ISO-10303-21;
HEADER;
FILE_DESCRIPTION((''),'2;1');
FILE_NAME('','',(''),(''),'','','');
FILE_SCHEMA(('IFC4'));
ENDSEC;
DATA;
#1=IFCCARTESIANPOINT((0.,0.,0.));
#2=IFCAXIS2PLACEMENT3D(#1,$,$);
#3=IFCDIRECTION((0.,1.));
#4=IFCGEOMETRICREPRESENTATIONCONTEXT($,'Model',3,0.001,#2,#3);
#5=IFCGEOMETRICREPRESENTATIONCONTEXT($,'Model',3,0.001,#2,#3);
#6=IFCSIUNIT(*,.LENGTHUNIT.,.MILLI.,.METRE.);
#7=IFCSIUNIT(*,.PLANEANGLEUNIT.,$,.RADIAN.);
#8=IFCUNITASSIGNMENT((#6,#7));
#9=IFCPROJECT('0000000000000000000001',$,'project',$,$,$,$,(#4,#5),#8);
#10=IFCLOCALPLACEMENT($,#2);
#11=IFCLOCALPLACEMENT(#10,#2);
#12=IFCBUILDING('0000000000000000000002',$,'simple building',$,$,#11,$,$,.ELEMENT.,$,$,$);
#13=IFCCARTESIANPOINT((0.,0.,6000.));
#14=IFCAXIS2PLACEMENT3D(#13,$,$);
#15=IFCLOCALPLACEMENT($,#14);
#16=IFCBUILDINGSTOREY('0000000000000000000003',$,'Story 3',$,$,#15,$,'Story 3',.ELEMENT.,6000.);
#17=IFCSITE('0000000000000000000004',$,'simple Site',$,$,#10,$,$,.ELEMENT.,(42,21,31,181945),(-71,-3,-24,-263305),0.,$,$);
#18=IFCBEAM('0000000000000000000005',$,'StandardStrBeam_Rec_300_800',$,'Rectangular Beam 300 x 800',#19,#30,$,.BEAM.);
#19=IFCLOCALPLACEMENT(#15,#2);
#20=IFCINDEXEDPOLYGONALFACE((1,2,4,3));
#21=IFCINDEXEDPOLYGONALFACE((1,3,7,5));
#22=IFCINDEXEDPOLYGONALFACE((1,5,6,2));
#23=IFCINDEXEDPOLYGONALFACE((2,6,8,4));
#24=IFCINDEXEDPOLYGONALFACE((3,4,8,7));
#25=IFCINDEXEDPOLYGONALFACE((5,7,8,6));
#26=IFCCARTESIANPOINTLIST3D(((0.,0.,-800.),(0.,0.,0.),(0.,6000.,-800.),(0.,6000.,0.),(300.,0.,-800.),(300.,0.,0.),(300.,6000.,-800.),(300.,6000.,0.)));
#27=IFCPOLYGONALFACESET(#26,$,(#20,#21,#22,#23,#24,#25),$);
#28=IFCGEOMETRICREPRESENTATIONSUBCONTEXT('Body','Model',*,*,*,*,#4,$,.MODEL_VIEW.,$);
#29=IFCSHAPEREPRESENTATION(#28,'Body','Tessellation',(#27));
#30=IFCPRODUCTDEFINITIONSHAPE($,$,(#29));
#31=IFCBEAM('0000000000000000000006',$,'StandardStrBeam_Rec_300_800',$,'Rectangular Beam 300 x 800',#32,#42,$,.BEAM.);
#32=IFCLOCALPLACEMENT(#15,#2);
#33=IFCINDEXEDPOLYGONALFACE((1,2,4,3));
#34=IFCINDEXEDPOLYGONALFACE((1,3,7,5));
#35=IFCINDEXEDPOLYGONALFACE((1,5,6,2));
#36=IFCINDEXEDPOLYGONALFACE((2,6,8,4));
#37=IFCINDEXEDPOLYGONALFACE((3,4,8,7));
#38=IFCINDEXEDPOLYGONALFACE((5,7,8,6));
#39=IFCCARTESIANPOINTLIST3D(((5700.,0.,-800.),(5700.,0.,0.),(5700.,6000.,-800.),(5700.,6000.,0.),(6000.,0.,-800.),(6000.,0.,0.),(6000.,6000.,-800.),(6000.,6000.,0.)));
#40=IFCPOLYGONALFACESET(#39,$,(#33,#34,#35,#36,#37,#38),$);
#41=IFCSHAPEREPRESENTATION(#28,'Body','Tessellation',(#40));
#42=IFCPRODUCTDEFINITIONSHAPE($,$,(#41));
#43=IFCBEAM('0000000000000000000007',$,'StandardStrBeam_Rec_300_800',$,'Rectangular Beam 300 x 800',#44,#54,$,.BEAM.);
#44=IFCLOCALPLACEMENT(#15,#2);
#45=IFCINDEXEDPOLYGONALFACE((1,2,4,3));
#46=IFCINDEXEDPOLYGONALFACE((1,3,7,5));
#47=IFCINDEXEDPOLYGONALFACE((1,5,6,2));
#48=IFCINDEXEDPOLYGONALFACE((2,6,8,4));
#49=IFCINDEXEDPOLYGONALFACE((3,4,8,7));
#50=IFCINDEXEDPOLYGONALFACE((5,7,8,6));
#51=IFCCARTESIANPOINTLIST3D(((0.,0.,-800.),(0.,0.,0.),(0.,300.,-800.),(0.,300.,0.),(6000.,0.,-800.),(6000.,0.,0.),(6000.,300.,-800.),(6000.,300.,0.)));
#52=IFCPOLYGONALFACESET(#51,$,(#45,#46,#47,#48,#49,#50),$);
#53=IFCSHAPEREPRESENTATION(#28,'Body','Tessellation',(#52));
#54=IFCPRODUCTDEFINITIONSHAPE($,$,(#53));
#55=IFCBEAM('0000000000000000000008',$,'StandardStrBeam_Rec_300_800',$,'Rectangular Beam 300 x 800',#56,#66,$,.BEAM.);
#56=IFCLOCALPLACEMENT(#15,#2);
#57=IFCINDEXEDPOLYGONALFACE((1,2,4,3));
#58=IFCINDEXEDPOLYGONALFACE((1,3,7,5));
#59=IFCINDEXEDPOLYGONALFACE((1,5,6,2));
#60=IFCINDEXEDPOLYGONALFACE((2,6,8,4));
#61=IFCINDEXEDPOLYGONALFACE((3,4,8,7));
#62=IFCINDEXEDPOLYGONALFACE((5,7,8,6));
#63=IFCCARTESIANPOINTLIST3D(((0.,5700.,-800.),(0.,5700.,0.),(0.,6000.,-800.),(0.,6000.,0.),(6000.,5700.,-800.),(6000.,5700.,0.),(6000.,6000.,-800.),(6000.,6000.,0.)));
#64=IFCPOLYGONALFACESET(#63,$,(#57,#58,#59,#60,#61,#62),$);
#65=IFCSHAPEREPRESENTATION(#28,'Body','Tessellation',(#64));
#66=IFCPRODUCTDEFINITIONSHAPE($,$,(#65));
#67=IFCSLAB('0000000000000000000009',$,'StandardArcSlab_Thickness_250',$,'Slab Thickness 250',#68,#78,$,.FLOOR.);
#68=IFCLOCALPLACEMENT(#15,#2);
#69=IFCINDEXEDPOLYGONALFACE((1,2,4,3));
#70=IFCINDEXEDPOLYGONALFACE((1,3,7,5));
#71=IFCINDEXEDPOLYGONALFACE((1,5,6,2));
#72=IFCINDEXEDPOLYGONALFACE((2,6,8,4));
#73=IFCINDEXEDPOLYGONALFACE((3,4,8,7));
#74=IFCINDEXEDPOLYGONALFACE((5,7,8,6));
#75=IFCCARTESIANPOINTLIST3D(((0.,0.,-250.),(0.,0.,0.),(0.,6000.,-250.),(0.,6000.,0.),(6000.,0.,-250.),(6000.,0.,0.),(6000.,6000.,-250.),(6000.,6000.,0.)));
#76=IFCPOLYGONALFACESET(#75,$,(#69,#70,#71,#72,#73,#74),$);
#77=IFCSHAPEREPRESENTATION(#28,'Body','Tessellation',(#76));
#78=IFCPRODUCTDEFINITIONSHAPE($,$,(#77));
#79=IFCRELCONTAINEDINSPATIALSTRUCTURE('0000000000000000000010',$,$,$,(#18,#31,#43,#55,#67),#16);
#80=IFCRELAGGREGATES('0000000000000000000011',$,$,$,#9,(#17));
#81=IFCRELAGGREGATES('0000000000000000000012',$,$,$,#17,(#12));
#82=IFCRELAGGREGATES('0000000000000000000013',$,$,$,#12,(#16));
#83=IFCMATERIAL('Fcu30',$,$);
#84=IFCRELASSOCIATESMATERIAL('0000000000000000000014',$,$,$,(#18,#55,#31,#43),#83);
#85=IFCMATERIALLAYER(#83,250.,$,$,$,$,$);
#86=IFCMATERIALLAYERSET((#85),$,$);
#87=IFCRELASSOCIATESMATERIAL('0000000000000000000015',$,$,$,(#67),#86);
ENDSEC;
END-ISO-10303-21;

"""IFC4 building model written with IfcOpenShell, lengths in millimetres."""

from ifc_helpers import new_model, si_unit, direction, frame, origin, origin_with_axes, origin_2d_with_axis, place, context, subcontext, project, spatial, polyline, rectangle, outline, extrude, material, layer, layer_set, layer_usage, material_profile, profile_set, profile_usage, element, save


model = new_model("IFC4")

# Units and contexts
model_context_1 = context("Model", 3, precision=0.001, world=origin(), true_north=direction((0.0, 1.0)))
model_context_2 = context("Model", 3, precision=0.001, world=origin(), true_north=direction((0.0, 1.0)))
body_context = subcontext(model_context_1, "Body", "Model", "MODEL_VIEW")
ifc_project = project(units=[si_unit("LENGTHUNIT", "METRE", prefix="MILLI"), si_unit("PLANEANGLEUNIT", "RADIAN")], contexts=[model_context_1, model_context_2])

# Site, building, storey
site_placement = place(None, origin())
site = spatial("IfcSite", under=ifc_project, at=site_placement, Name="simple Site", CompositionType="ELEMENT", RefLatitude=(42, 21, 31, 181945), RefLongitude=(-71, -3, -24, -263305), RefElevation=0.0)
building_placement = place(site_placement, origin())
building = spatial("IfcBuilding", under=site, at=building_placement, Name="simple building", CompositionType="ELEMENT")
storey_placement = place(None, frame((0.0, 0.0, 6000.0)))
storey = spatial("IfcBuildingStorey", under=building, at=storey_placement, Name="Story 3", LongName="Story 3", CompositionType="ELEMENT", Elevation=6000.0)

# Beams
ifc_material = material(Name="Fcu30")
ifc_material_profile = material_profile(ifc_material, rectangle(XDim=300.0, YDim=800.0, at=origin_2d_with_axis()))
ifc_profile_set = profile_set([ifc_material_profile])
ifc_profile_usage_1 = profile_usage(ifc_profile_set, cardinal=7)
beam_1_placement = place(None, frame((150.0, 0.0, 5600.0), z_axis=(0.0, 1.0, 0.0), x_axis=(1.0, 0.0, 0.0)))
element("IfcBeam", 1, at=beam_1_placement, inside=storey, material=ifc_profile_usage_1, Name="StandardStrBeam_Rec_300_800", ObjectType="Rectangular Beam 300 x 800", PredefinedType="BEAM", context=body_context, shape_type="SweptSolid", body=[
    extrude(rectangle(XDim=300.0, YDim=800.0, at=origin_2d_with_axis()), origin_with_axes(), (0.0, 0.0, 1.0), 6000.0),
])
ifc_profile_usage_2 = profile_usage(ifc_profile_set, cardinal=9)
for number, where, z_axis, x_axis, name in (
    (2, (5850.0, 0.0, 5600.0), (0.0, 1.0, 0.0), (1.0, 0.0, 0.0), "StandardStrBeam_Rec_300_800"),
    (3, (0.0, 150.0, 5600.0), (1.0, 0.0, 0.0), (0.0, -1.0, 0.0), "StandardStrBeam_Rec_300_800"),
):
    element("IfcBeam", number, at=place(None, frame(where, z_axis=z_axis, x_axis=x_axis)), inside=storey, material=ifc_profile_usage_2, Name=name, ObjectType="Rectangular Beam 300 x 800", PredefinedType="BEAM", context=body_context, shape_type="SweptSolid", body=[
        extrude(rectangle(XDim=300.0, YDim=800.0, at=origin_2d_with_axis()), origin_with_axes(), (0.0, 0.0, 1.0), 6000.0),
    ])
beam_2_placement = place(None, frame((0.0, 5850.0, 5600.0), z_axis=(1.0, 0.0, 0.0), x_axis=(0.0, -1.0, 0.0)))
element("IfcBeam", 4, at=beam_2_placement, inside=storey, material=ifc_profile_usage_1, Name="StandardStrBeam_Rec_300_800", ObjectType="Rectangular Beam 300 x 800", PredefinedType="BEAM", context=body_context, shape_type="SweptSolid", body=[
    extrude(rectangle(XDim=300.0, YDim=800.0, at=origin_2d_with_axis()), origin_with_axes(), (0.0, 0.0, 1.0), 6000.0),
])

# Slab
ifc_layer = layer(ifc_material, 250.0)
ifc_layer_set = layer_set([ifc_layer])
ifc_layer_usage = layer_usage(ifc_layer_set, "AXIS3", "POSITIVE", -250.0)
slab_placement = place(None, frame((0.0, 0.0, 5750.0), z_axis=(0.0, 0.0, 1.0), x_axis=(1.0, 0.0, 0.0)))
element("IfcSlab", 5, at=slab_placement, inside=storey, material=ifc_layer_usage, Name="StandardArcSlab_Thickness_250", ObjectType="Slab Thickness 250", PredefinedType="FLOOR", context=body_context, shape_type="SweptSolid", body=[
    extrude(outline(polyline([(0.0, 0.0), (6000.0, 0.0), (6000.0, 6000.0), (0.0, 6000.0), (0.0, 0.0)])), origin_with_axes(), (0.0, 0.0, 1.0), 250.0),
])

save(model, "model.ifc")
